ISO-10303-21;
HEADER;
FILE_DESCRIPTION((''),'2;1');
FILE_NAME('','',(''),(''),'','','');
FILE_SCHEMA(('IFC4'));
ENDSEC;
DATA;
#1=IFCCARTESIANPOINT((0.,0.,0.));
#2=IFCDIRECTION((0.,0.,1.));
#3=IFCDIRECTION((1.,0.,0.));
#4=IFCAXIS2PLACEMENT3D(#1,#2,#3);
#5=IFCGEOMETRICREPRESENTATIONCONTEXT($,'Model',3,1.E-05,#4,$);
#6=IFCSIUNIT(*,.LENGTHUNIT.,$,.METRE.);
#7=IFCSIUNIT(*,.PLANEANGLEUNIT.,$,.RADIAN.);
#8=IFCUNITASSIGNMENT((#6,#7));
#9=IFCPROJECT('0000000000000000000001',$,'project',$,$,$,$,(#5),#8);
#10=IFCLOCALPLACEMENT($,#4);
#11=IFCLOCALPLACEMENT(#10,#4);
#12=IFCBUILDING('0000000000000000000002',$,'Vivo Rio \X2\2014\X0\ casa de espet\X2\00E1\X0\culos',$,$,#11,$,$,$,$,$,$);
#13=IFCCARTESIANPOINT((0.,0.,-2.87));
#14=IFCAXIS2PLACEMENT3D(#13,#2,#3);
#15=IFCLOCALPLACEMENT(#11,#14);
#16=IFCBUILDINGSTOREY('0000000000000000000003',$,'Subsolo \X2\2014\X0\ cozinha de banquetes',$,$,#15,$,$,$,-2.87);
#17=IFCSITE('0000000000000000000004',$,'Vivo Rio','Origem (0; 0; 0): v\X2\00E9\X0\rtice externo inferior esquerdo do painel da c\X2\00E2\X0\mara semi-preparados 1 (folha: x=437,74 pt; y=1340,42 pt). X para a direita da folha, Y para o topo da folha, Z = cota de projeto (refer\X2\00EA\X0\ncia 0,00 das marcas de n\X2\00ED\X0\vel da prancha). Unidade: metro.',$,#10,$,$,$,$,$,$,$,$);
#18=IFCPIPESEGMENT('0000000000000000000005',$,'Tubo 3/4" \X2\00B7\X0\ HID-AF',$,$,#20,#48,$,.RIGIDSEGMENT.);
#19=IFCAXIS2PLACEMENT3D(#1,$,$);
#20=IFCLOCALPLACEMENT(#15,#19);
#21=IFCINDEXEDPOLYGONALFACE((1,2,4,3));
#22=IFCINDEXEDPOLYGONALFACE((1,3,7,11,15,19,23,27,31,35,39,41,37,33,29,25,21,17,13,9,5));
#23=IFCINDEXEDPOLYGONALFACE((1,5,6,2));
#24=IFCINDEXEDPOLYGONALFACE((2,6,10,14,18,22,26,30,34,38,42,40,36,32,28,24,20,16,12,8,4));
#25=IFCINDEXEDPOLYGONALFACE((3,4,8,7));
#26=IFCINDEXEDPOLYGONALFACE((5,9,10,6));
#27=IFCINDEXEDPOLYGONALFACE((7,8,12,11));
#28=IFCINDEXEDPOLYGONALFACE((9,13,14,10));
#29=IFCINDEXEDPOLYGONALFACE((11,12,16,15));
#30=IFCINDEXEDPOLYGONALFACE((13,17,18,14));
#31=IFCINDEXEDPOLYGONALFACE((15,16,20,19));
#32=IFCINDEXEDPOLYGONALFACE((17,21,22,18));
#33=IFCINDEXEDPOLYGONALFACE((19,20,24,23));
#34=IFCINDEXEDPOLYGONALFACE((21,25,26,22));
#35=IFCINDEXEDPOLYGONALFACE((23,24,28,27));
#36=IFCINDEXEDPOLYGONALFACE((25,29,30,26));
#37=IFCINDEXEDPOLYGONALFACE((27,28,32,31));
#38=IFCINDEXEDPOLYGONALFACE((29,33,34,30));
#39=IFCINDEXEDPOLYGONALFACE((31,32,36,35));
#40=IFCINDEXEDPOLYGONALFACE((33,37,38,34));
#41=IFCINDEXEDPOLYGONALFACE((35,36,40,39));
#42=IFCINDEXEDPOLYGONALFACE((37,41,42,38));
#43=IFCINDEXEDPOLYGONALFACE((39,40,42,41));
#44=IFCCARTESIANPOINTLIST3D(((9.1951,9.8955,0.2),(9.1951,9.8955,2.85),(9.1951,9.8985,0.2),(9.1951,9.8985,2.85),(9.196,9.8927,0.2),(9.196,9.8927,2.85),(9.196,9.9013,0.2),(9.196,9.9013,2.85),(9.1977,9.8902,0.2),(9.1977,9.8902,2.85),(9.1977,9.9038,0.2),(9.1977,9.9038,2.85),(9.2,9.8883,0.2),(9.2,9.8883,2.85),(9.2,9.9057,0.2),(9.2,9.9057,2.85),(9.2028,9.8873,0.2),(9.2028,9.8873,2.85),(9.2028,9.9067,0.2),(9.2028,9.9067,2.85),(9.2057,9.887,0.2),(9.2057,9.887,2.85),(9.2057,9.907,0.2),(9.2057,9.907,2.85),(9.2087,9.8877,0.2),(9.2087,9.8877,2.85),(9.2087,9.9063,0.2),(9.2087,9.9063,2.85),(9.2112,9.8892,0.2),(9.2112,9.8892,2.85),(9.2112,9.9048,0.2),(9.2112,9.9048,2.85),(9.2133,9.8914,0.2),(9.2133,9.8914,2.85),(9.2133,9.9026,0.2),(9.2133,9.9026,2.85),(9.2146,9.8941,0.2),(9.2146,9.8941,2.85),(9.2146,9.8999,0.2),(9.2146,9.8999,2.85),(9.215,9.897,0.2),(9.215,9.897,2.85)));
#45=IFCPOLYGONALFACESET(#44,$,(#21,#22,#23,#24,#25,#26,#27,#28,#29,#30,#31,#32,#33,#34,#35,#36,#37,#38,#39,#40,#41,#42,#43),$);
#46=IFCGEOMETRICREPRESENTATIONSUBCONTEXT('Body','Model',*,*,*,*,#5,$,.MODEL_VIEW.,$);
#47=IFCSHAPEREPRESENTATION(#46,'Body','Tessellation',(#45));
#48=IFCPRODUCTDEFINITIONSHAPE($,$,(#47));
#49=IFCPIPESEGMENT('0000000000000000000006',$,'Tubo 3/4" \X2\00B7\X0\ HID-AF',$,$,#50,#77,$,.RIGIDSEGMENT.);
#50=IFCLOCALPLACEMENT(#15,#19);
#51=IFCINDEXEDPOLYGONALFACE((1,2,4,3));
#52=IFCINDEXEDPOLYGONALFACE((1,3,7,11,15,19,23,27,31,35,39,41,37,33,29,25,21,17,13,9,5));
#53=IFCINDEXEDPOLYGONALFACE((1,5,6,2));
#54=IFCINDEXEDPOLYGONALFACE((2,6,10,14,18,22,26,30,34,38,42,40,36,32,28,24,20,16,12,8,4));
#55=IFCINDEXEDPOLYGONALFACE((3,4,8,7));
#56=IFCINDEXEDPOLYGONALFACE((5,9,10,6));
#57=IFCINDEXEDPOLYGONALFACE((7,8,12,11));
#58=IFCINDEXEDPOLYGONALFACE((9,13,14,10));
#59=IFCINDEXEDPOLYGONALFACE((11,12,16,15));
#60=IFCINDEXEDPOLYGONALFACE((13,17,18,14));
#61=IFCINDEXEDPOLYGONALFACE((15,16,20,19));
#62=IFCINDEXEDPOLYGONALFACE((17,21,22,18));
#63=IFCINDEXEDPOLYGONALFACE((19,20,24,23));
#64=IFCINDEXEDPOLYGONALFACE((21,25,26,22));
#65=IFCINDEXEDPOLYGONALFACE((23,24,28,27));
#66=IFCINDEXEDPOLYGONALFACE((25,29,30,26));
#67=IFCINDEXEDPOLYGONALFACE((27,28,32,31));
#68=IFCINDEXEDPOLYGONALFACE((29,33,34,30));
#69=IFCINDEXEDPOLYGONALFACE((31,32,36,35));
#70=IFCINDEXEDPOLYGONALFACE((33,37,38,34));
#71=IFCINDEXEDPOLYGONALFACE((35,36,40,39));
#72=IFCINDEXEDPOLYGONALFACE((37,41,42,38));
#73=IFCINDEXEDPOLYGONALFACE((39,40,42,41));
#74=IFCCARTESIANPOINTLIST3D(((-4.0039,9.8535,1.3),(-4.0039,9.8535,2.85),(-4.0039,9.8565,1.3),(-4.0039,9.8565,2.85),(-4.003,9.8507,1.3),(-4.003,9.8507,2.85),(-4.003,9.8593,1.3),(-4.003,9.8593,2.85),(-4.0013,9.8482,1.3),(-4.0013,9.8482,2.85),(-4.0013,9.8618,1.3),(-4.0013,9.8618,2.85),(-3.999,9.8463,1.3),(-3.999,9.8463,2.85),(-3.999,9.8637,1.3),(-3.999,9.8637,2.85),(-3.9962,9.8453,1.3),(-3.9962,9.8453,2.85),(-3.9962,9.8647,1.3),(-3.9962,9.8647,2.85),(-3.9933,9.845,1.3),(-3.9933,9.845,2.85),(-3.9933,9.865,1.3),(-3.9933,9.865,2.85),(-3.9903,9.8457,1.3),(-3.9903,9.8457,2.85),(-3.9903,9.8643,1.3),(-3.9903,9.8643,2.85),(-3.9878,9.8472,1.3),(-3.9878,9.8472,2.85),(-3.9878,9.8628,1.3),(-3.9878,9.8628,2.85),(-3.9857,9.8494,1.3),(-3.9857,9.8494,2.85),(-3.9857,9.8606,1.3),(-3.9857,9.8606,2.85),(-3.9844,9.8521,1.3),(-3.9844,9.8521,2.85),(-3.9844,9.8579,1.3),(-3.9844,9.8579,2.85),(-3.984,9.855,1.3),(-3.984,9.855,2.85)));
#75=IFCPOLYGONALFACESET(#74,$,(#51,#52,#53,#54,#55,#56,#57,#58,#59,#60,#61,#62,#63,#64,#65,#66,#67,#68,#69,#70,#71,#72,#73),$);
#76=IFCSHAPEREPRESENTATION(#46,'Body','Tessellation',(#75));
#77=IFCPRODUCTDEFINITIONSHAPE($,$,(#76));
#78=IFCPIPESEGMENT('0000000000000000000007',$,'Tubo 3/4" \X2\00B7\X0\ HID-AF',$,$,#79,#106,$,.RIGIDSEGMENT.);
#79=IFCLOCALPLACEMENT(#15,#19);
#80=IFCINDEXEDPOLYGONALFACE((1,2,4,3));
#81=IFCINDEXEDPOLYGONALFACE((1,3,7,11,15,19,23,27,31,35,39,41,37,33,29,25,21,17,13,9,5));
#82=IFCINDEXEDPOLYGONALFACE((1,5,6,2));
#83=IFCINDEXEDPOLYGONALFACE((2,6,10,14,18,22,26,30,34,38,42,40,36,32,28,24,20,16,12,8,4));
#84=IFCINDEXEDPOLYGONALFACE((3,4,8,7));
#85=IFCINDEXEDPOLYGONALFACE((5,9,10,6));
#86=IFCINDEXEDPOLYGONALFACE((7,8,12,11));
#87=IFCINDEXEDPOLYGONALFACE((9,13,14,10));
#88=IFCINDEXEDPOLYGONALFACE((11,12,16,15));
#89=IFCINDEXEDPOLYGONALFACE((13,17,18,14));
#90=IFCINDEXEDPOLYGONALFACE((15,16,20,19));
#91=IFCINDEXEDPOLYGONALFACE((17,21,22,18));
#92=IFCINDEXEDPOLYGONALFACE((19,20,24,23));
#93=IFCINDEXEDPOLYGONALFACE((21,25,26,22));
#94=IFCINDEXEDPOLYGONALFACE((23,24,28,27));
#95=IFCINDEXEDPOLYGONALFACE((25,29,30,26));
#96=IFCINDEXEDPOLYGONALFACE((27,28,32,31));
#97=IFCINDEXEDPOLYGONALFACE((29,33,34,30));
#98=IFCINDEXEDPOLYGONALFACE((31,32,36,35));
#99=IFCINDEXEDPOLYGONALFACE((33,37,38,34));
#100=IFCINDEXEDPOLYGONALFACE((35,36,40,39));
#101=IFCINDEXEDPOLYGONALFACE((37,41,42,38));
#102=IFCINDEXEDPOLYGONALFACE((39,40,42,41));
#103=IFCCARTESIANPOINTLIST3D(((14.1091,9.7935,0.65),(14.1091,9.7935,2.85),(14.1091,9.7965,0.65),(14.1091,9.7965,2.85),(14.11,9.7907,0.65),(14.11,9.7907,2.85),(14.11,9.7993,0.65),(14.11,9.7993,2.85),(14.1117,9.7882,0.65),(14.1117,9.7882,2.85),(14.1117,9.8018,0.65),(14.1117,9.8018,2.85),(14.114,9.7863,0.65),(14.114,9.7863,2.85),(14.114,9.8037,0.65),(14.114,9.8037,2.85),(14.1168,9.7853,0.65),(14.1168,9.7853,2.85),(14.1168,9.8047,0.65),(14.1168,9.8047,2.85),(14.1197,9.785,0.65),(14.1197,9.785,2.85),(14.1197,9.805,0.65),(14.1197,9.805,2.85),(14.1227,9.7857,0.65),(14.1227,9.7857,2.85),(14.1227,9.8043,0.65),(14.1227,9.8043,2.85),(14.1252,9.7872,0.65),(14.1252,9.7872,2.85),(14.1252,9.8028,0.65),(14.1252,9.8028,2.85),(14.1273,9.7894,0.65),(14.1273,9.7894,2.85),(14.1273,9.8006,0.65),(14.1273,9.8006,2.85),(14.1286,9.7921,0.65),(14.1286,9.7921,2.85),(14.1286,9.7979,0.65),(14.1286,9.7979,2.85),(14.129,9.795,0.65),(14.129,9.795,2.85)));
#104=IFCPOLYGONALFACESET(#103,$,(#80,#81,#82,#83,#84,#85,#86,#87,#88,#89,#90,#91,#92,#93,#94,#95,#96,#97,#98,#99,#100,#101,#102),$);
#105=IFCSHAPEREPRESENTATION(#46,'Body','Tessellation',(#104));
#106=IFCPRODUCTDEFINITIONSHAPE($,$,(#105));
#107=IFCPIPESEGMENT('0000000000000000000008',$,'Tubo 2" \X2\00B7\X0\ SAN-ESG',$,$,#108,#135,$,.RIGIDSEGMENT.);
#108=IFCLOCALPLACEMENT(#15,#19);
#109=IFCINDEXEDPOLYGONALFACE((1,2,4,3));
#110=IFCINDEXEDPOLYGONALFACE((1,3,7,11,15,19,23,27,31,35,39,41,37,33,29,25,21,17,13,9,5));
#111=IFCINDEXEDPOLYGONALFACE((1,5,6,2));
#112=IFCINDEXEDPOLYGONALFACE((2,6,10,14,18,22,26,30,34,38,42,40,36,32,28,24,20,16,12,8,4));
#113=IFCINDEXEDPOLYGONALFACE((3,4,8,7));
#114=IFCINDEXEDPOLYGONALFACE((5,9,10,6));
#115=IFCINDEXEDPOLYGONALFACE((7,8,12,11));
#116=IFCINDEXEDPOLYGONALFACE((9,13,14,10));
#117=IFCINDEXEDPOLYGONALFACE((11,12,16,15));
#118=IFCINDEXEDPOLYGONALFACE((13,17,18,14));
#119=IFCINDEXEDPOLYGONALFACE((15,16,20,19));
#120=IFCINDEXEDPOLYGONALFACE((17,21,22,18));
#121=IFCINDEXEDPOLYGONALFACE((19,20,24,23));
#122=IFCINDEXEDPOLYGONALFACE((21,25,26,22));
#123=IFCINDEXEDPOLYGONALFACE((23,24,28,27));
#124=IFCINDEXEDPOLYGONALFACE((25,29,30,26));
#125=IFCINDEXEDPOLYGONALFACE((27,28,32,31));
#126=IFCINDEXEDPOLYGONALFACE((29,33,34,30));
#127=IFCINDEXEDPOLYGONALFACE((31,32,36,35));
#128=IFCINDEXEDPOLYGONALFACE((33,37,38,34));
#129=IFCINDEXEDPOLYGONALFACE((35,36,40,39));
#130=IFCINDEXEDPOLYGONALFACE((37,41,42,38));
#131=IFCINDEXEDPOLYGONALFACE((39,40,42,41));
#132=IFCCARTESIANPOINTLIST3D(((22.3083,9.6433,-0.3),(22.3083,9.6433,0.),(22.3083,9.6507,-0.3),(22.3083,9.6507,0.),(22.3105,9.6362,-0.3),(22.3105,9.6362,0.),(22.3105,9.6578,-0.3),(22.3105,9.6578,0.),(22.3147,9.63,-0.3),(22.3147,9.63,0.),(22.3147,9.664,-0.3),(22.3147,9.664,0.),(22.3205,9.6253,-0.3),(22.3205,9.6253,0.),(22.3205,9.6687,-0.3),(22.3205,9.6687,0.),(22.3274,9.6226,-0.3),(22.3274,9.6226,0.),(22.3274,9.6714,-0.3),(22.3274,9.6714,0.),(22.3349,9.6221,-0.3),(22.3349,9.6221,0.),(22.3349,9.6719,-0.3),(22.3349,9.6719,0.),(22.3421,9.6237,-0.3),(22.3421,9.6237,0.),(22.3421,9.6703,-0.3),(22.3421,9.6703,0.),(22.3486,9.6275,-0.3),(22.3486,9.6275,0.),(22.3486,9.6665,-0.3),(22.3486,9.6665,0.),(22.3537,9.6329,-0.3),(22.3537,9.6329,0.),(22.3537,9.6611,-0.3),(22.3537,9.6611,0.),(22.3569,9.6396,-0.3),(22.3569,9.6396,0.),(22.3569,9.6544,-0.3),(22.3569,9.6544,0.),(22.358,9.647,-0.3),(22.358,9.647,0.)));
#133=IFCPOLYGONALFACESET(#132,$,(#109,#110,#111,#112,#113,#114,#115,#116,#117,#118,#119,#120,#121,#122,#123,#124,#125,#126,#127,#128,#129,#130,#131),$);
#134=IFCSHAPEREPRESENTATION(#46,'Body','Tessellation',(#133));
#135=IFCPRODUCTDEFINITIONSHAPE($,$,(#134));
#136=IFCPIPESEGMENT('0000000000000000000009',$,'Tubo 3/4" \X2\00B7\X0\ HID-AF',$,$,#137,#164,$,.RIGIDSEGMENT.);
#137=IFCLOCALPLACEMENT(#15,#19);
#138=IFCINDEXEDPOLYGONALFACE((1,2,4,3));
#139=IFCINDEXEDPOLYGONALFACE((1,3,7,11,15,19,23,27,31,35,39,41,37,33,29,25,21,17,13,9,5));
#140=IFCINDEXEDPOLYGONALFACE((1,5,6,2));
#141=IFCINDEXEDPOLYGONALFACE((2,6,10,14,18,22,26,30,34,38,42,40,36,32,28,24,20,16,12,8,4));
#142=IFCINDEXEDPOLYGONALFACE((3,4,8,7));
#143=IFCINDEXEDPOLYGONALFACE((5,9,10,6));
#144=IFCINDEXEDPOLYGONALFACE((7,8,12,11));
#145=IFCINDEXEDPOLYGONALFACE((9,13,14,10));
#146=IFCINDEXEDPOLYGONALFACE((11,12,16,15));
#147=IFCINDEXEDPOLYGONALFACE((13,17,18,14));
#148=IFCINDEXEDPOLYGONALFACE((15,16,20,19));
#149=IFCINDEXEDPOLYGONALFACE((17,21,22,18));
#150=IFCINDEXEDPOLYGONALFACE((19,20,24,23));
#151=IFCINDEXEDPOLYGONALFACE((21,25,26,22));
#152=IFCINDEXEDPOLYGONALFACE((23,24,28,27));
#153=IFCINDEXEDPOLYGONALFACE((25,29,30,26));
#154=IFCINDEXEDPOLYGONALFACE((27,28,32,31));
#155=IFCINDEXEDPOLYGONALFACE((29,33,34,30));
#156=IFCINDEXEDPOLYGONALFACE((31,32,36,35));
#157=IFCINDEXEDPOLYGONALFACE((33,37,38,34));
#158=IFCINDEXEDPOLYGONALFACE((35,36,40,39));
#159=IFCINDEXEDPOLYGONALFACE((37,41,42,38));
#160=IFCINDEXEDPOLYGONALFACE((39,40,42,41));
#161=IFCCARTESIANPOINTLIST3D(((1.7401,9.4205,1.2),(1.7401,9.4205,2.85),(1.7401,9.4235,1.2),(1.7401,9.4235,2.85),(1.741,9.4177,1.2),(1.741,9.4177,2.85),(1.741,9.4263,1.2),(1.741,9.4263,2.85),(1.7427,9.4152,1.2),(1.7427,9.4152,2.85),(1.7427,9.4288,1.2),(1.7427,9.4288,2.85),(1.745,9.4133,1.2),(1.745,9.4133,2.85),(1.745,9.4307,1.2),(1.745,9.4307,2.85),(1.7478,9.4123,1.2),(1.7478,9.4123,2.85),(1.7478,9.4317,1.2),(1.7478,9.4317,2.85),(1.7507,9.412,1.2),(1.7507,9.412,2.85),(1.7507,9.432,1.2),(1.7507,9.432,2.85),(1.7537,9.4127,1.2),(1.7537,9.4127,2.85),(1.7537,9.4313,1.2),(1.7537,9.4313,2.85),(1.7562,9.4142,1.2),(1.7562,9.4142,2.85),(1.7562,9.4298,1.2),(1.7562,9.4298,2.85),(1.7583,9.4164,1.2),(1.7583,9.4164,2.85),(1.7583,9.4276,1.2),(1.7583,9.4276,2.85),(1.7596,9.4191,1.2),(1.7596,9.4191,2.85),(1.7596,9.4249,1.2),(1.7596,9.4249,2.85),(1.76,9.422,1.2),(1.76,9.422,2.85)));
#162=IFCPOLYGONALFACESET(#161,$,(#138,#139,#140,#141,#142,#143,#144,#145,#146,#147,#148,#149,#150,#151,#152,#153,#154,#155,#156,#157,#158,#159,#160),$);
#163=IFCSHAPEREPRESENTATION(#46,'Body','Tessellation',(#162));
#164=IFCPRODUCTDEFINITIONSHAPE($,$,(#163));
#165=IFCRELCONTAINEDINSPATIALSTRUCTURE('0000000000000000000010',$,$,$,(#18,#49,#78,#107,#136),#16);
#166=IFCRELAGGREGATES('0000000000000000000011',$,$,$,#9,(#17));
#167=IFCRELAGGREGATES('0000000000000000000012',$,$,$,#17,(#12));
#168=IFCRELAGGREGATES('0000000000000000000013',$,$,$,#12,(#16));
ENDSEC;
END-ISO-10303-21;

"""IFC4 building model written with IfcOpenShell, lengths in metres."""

from ifc_helpers import new_model, si_unit, frame, origin_with_axes, origin_2d, place, context, subcontext, project, spatial, circle, extrude, element, save


model = new_model("IFC4")

# Units and contexts
model_context = context("Model", 3, precision=1e-05, world=origin_with_axes())
body_context = subcontext(model_context, "Body", "Model", "MODEL_VIEW")
ifc_project = project(units=[si_unit("LENGTHUNIT", "METRE"), si_unit("PLANEANGLEUNIT", "RADIAN")], contexts=[model_context])

# Site, building, storey
site_placement = place(None, origin_with_axes())
site = spatial("IfcSite", under=ifc_project, at=site_placement, Name="Vivo Rio", Description="Origem (0; 0; 0): vértice externo inferior esquerdo do painel da câmara semi-preparados 1 (folha: x=437,74 pt; y=1340,42 pt). X para a direita da folha, Y para o topo da folha, Z = cota de projeto (referência 0,00 das marcas de nível da prancha). Unidade: metro.")
building_placement = place(site_placement, origin_with_axes())
building = spatial("IfcBuilding", under=site, at=building_placement, Name="Vivo Rio — casa de espetáculos")
storey_placement = place(building_placement, frame((0.0, 0.0, -2.87), z_axis=(0.0, 0.0, 1.0), x_axis=(1.0, 0.0, 0.0)))
storey = spatial("IfcBuildingStorey", under=building, at=storey_placement, Name="Subsolo — cozinha de banquetes", Elevation=-2.87)

# Pipe segments
pipe_segment_1_placement = place(storey_placement, origin_with_axes())
element("IfcPipeSegment", 1, at=pipe_segment_1_placement, inside=storey, Name="Tubo 3/4\" · HID-AF", PredefinedType="RIGIDSEGMENT", context=body_context, shape_type="SweptSolid", body=[
    extrude(circle(Radius=0.01, at=origin_2d()), frame((9.205, 9.897, 2.85), z_axis=(0.0, 0.0, -1.0), x_axis=(1.0, 0.0, 0.0)), (0.0, 0.0, 1.0), 2.65),
])
pipe_segment_2_placement = place(storey_placement, origin_with_axes())
element("IfcPipeSegment", 2, at=pipe_segment_2_placement, inside=storey, Name="Tubo 3/4\" · HID-AF", PredefinedType="RIGIDSEGMENT", context=body_context, shape_type="SweptSolid", body=[
    extrude(circle(Radius=0.01, at=origin_2d()), frame((-3.994, 9.855, 2.85), z_axis=(0.0, 0.0, -1.0), x_axis=(1.0, 0.0, 0.0)), (0.0, 0.0, 1.0), 1.55),
])
pipe_segment_3_placement = place(storey_placement, origin_with_axes())
element("IfcPipeSegment", 3, at=pipe_segment_3_placement, inside=storey, Name="Tubo 3/4\" · HID-AF", PredefinedType="RIGIDSEGMENT", context=body_context, shape_type="SweptSolid", body=[
    extrude(circle(Radius=0.01, at=origin_2d()), frame((14.119, 9.795, 2.85), z_axis=(0.0, 0.0, -1.0), x_axis=(1.0, 0.0, 0.0)), (0.0, 0.0, 1.0), 2.2),
])
pipe_segment_4_placement = place(storey_placement, origin_with_axes())
element("IfcPipeSegment", 4, at=pipe_segment_4_placement, inside=storey, Name="Tubo 2\" · SAN-ESG", PredefinedType="RIGIDSEGMENT", context=body_context, shape_type="SweptSolid", body=[
    extrude(circle(Radius=0.025, at=origin_2d()), frame((22.333, 9.647, 0.0), z_axis=(0.0, 0.0, -1.0), x_axis=(1.0, 0.0, 0.0)), (0.0, 0.0, 1.0), 0.3),
])
pipe_segment_5_placement = place(storey_placement, origin_with_axes())
element("IfcPipeSegment", 5, at=pipe_segment_5_placement, inside=storey, Name="Tubo 3/4\" · HID-AF", PredefinedType="RIGIDSEGMENT", context=body_context, shape_type="SweptSolid", body=[
    extrude(circle(Radius=0.01, at=origin_2d()), frame((1.75, 9.422, 2.85), z_axis=(0.0, 0.0, -1.0), x_axis=(1.0, 0.0, 0.0)), (0.0, 0.0, 1.0), 1.65),
])

save(model, "model.ifc")
